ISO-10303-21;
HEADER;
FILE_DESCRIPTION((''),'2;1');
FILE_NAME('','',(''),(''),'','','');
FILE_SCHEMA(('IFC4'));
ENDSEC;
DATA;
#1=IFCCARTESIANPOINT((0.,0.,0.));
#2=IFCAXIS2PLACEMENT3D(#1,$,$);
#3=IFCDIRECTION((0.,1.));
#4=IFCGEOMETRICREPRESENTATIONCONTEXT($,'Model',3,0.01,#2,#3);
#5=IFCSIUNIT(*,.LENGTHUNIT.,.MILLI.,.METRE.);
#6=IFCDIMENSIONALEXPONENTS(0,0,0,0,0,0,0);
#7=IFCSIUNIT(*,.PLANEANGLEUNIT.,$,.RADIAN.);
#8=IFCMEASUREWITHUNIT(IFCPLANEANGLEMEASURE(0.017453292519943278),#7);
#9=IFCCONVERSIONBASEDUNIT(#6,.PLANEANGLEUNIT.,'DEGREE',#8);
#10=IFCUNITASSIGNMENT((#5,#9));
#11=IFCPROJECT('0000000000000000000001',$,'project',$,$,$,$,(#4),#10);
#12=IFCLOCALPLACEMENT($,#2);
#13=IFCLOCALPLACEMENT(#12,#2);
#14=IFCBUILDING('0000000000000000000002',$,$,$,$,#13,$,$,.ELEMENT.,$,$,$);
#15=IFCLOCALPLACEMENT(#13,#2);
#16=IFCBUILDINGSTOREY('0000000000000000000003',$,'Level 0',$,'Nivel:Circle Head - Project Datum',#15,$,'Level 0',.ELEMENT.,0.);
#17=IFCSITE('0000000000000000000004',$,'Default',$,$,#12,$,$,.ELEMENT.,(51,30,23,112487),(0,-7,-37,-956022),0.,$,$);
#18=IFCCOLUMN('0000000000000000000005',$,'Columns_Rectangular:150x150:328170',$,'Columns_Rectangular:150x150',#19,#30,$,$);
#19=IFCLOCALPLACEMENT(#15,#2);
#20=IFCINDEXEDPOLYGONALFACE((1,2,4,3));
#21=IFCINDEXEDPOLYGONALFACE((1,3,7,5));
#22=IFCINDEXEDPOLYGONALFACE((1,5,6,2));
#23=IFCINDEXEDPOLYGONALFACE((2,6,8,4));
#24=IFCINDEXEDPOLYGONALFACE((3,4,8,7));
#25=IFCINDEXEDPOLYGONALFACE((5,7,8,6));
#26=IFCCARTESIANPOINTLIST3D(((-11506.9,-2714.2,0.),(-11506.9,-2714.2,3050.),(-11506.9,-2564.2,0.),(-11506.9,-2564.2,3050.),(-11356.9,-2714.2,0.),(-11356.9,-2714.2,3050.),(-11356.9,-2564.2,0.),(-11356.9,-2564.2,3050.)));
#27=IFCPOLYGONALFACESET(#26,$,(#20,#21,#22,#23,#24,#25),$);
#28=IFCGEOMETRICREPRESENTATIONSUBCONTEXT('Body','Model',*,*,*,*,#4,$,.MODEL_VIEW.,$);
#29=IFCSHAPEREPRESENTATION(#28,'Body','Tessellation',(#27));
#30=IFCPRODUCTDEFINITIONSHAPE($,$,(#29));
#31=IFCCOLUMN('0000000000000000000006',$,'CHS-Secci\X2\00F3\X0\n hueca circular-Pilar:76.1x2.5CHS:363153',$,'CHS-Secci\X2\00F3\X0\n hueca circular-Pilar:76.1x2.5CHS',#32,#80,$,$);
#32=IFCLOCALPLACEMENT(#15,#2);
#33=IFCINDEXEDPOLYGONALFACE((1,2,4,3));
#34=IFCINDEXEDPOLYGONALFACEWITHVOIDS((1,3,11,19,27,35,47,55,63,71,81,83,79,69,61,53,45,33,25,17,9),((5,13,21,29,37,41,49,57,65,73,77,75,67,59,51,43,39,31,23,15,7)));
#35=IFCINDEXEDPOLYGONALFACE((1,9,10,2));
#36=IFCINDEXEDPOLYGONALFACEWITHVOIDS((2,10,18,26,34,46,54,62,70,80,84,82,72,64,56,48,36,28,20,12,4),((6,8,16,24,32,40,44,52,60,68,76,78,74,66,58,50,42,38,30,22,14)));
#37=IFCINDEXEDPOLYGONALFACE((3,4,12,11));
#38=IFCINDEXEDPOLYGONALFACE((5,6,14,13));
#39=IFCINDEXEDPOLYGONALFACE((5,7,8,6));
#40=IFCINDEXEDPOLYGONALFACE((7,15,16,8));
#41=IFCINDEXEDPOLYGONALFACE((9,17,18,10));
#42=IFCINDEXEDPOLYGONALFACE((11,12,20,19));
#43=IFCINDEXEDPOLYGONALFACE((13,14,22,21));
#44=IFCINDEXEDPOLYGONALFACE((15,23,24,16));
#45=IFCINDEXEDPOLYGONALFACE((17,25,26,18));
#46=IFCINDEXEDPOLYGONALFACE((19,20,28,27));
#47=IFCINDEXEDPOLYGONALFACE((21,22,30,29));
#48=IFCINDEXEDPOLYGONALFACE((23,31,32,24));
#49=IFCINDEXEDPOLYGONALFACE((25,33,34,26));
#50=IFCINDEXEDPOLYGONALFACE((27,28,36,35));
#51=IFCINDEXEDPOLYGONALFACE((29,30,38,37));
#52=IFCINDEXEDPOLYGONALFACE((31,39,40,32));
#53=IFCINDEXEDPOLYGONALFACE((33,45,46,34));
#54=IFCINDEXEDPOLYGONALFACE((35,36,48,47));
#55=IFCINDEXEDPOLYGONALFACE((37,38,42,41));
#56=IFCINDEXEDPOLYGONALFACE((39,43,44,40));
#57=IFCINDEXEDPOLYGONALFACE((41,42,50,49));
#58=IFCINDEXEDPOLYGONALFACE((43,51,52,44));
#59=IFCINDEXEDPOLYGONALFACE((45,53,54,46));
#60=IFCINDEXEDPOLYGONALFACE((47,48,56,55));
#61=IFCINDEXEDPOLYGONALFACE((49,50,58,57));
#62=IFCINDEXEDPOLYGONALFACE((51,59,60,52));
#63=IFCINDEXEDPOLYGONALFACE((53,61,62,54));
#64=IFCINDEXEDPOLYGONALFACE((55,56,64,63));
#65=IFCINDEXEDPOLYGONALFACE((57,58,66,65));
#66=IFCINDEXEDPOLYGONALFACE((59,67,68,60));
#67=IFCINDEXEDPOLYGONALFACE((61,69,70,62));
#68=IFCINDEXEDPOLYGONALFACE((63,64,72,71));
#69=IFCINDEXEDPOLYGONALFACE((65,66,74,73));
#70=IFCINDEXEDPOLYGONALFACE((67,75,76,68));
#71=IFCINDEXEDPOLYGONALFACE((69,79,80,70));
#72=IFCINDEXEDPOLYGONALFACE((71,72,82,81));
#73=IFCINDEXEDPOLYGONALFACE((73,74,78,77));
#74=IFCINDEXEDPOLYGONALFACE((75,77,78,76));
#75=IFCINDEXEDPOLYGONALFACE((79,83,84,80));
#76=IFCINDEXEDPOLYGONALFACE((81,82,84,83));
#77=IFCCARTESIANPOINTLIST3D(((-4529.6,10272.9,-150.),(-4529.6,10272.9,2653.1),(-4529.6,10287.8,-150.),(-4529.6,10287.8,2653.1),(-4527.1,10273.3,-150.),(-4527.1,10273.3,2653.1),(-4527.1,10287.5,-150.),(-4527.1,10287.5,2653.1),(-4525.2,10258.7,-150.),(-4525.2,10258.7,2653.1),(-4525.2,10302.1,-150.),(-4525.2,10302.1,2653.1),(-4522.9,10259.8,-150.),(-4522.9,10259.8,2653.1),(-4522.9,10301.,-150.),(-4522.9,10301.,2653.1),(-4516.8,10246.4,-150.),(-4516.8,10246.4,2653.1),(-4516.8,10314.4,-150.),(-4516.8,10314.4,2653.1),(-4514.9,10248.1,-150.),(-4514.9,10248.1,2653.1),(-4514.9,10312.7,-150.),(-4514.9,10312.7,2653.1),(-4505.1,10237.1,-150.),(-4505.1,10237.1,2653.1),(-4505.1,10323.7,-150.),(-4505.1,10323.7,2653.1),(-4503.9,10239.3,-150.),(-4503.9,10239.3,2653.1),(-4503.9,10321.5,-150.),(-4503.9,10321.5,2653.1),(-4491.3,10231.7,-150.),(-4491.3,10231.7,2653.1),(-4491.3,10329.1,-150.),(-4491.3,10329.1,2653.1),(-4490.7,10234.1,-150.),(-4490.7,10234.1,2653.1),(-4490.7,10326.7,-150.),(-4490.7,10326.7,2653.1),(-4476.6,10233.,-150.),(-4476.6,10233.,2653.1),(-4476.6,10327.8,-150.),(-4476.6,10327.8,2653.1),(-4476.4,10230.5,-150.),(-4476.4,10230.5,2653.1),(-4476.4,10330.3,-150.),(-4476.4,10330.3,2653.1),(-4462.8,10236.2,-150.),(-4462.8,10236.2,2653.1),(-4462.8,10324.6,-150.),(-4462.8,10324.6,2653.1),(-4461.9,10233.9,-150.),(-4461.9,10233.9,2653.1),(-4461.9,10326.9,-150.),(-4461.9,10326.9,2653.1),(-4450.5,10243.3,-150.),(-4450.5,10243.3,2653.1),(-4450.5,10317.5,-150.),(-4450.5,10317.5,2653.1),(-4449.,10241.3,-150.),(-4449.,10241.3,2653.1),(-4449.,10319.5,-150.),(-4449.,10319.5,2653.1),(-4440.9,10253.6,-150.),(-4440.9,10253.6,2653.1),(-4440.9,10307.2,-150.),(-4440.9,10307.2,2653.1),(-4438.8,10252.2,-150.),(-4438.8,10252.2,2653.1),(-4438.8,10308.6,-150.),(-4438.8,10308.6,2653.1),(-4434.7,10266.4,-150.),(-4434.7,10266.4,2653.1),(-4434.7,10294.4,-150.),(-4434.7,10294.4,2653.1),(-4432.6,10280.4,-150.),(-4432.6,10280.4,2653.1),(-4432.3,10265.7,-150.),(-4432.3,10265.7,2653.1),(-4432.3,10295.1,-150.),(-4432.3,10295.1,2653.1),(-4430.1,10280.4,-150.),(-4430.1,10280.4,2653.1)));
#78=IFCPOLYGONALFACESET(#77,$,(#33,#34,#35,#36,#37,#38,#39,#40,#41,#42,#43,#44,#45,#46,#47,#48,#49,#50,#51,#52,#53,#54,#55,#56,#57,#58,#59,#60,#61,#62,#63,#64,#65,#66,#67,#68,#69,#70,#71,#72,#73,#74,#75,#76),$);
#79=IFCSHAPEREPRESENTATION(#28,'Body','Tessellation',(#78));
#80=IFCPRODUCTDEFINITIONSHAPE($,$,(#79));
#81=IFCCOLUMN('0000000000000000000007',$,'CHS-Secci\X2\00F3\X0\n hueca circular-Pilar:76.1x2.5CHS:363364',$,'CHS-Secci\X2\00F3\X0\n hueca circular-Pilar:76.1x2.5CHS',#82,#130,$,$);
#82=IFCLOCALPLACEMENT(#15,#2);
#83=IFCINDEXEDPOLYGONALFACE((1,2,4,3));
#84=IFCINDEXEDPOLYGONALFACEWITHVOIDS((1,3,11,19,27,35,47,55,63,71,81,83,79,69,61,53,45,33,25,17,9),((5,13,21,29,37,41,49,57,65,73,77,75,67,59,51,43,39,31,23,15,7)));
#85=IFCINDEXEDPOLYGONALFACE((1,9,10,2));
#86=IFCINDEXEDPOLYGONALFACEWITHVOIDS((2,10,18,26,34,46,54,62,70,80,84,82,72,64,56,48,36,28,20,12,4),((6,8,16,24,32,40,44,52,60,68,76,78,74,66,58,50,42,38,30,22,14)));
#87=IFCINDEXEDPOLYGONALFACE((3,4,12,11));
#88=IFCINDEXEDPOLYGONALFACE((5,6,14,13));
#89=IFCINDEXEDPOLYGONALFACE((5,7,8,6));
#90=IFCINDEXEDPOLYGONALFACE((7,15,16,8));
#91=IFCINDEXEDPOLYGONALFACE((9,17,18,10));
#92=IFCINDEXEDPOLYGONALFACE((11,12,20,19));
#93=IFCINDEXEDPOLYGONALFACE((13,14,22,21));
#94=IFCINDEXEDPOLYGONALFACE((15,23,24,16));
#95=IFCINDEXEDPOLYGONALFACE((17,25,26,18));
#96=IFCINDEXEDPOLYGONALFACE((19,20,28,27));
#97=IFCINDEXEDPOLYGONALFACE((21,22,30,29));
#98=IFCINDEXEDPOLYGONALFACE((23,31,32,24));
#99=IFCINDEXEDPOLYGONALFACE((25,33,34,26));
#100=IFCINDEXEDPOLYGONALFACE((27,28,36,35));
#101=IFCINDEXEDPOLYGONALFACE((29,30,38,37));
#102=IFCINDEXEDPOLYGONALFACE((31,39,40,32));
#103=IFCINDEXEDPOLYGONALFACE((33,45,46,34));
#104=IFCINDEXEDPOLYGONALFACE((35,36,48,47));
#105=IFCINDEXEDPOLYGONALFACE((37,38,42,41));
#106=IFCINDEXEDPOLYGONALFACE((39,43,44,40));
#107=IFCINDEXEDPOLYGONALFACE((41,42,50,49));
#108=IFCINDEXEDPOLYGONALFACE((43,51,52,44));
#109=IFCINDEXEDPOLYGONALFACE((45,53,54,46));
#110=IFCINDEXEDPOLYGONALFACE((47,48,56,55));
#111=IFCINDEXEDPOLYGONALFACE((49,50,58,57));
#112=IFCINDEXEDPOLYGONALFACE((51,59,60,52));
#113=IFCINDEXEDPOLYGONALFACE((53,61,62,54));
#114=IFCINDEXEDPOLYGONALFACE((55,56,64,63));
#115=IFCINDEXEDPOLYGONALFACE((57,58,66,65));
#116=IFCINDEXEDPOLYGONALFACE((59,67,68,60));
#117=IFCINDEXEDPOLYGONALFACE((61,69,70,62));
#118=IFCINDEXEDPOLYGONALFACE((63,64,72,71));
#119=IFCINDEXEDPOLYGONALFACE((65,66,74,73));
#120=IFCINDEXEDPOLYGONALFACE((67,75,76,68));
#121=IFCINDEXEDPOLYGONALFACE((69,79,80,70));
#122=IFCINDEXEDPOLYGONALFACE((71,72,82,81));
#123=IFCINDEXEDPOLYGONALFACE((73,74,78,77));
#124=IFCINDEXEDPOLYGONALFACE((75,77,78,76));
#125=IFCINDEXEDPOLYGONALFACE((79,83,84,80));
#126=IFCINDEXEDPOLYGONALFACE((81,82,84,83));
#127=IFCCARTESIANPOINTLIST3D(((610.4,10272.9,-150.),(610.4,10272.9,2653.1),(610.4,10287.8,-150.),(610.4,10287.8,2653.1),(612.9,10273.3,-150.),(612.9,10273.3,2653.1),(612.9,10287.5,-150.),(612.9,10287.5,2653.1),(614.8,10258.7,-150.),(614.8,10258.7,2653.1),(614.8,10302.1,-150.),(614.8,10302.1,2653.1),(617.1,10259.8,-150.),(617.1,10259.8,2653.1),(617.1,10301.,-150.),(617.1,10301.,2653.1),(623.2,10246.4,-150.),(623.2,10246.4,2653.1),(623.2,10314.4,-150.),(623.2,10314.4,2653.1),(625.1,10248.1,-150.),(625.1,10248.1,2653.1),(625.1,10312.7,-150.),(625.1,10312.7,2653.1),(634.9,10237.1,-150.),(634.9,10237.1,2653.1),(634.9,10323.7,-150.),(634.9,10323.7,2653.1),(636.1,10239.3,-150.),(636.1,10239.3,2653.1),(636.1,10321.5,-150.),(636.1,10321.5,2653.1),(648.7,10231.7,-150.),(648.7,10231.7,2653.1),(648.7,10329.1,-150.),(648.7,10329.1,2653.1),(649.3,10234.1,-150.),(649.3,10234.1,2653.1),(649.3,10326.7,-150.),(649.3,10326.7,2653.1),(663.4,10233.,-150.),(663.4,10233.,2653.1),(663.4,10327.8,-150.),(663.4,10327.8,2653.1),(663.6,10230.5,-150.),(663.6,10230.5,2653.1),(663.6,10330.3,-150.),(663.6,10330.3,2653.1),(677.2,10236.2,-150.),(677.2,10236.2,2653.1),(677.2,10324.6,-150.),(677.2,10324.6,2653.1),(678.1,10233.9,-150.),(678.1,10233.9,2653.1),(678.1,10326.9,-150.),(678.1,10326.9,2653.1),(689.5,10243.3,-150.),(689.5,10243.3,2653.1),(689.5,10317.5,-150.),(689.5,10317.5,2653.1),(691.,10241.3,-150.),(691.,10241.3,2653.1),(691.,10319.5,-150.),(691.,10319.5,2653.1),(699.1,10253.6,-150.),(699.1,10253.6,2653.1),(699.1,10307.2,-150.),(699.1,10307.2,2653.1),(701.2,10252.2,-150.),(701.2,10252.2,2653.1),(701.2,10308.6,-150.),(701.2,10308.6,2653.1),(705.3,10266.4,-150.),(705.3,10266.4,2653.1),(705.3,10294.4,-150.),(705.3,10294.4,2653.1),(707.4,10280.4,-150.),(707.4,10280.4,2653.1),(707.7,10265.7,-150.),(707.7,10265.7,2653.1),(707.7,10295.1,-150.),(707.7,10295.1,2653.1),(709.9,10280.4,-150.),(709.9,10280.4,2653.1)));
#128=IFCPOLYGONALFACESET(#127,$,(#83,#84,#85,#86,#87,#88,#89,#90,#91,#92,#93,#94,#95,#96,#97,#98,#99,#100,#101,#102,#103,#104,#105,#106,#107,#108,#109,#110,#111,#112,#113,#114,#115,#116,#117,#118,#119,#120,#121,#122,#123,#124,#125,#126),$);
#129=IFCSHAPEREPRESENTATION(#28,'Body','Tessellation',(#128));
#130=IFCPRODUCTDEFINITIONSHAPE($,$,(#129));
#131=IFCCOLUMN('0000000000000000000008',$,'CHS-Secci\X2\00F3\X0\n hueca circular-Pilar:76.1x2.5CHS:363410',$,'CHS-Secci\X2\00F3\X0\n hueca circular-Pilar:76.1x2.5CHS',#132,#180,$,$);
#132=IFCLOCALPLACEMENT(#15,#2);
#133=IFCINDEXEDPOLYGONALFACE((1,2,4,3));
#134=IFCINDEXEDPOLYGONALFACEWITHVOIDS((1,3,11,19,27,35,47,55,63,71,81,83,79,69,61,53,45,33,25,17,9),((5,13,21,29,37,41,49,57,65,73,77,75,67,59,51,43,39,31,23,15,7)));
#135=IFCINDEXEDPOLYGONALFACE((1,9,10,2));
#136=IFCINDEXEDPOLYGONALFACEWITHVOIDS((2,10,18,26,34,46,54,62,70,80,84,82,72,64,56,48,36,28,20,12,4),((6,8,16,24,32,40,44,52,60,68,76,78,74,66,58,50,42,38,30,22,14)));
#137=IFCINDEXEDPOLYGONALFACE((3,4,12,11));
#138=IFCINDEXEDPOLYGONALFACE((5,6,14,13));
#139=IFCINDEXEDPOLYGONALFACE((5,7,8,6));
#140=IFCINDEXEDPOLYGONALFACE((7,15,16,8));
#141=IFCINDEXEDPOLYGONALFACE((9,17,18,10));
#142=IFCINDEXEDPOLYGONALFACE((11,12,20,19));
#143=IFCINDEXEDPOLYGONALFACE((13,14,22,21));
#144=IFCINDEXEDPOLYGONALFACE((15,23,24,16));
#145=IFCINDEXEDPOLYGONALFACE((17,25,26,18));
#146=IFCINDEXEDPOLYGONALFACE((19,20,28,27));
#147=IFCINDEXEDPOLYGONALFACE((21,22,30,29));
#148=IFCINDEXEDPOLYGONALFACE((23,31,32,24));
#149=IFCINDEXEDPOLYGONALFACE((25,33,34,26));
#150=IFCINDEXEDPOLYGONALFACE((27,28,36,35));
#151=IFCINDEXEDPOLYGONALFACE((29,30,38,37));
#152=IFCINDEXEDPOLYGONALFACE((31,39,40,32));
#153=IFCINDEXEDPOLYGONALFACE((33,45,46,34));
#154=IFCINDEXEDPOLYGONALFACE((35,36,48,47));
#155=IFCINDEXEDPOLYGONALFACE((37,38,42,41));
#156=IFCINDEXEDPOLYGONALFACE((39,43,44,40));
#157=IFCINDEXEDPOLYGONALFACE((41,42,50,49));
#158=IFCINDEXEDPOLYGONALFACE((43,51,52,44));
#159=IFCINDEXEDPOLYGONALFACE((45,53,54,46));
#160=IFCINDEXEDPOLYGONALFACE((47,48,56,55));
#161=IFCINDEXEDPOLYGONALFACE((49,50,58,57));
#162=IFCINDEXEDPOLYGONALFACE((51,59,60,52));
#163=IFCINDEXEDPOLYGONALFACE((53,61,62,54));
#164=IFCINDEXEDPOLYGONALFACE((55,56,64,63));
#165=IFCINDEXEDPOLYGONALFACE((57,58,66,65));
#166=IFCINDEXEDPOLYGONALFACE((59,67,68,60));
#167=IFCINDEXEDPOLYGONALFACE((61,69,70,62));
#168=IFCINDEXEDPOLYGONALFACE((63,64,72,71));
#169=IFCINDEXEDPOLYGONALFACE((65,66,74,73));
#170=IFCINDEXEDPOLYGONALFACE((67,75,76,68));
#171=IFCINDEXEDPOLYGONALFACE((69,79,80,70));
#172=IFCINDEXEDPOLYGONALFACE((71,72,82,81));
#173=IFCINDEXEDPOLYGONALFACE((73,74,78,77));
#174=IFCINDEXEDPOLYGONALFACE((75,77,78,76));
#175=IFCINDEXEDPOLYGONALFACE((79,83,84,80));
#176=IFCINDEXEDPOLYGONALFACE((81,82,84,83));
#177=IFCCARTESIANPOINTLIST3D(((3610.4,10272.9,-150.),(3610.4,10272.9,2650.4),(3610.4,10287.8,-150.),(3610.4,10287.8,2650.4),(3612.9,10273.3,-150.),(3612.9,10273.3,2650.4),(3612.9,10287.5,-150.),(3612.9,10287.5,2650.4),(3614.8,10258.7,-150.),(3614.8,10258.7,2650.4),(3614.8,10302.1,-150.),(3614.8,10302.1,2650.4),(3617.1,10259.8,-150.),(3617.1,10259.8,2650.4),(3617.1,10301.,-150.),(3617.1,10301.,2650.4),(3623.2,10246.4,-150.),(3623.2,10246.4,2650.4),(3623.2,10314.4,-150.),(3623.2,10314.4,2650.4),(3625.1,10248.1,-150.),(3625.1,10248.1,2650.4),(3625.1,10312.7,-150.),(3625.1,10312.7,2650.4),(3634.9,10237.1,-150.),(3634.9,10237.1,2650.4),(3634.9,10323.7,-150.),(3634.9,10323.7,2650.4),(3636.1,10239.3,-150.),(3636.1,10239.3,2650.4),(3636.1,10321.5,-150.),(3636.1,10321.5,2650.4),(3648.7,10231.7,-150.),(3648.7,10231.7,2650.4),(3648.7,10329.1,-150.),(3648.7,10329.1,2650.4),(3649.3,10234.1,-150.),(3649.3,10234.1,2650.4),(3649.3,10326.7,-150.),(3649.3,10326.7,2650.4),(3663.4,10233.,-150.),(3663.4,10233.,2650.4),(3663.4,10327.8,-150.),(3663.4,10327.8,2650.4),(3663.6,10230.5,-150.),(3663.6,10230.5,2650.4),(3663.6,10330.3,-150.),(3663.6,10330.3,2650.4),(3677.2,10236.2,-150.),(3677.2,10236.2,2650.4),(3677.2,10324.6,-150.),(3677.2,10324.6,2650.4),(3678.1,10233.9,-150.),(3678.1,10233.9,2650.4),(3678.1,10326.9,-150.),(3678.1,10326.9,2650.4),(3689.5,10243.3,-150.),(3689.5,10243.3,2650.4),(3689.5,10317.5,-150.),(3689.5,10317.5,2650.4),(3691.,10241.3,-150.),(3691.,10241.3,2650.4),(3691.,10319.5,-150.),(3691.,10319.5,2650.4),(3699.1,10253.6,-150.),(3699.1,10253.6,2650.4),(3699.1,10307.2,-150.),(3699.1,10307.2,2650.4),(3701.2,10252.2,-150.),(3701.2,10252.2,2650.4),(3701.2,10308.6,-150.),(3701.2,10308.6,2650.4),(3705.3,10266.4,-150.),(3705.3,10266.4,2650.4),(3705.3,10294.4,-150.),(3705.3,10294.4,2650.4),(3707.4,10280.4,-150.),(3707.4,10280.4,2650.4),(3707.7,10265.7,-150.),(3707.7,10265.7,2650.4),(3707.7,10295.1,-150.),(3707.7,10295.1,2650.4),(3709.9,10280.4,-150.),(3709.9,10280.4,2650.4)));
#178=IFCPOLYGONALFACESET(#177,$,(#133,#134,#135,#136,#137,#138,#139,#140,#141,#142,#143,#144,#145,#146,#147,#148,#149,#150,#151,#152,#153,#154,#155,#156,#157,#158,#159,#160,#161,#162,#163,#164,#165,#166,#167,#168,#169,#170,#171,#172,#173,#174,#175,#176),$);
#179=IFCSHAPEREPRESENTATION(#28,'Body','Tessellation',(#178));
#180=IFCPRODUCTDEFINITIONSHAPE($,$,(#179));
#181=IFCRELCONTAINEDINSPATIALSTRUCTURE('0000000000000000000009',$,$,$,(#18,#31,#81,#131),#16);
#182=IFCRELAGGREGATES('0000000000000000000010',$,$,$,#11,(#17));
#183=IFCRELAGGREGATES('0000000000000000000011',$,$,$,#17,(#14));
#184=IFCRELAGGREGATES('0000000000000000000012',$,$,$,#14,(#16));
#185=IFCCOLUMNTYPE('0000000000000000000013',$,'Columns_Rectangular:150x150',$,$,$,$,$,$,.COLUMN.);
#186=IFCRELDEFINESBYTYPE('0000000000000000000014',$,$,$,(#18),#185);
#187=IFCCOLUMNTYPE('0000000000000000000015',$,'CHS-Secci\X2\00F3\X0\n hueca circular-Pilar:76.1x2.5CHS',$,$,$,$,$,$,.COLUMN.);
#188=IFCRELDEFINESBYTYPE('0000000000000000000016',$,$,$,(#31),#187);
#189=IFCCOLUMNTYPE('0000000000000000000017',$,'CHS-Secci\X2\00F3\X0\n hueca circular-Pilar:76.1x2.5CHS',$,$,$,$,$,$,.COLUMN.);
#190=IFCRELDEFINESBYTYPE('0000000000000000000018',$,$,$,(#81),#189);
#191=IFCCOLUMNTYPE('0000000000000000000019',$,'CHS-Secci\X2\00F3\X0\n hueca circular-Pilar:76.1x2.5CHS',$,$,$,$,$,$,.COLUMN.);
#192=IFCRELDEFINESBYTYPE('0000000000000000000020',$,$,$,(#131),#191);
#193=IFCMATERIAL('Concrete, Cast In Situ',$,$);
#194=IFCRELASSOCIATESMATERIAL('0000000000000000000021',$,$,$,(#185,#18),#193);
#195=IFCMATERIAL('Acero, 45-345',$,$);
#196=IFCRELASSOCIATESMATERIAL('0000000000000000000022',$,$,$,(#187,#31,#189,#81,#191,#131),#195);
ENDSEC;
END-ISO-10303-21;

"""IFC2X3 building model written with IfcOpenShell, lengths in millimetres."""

from ifc_helpers import new_model, entity, si_unit, converted_unit, direction, frame, frame_2d, origin, origin_2d_with_axis, place, context, subcontext, project, spatial, rectangle, hollow_circle, extrude, source, transform, mapped, material, type_object, type_shapes, element, save


model = new_model("IFC2X3")

# Units and contexts
model_context = context("Model", 3, precision=0.01, world=origin(), true_north=direction((0.0, 1.0)))
body_context = subcontext(model_context, "Body", "Model", "MODEL_VIEW")
ifc_project = project(units=[si_unit("LENGTHUNIT", "METRE", prefix="MILLI"), converted_unit("PLANEANGLEUNIT", "DEGREE", entity("IfcPlaneAngleMeasure", 0.017453292519943278), si_unit("PLANEANGLEUNIT", "RADIAN"), dimensions=[0, 0, 0, 0, 0, 0, 0])], contexts=[model_context])

# Site, building, storey
site_placement = place(None, origin())
site = spatial("IfcSite", under=ifc_project, at=site_placement, Name="Default", CompositionType="ELEMENT", RefLatitude=(51, 30, 23, 112487), RefLongitude=(0, -7, -37, -956022), RefElevation=0.0)
building_placement = place(site_placement, origin())
building = spatial("IfcBuilding", under=site, at=building_placement, CompositionType="ELEMENT")
storey_placement = place(building_placement, origin())
storey = spatial("IfcBuildingStorey", under=building, at=storey_placement, Name="Level 0", ObjectType="Nivel:Circle Head - Project Datum", LongName="Level 0", CompositionType="ELEMENT", Elevation=0.0)

# Columns
ifc_material_1 = material(Name="Concrete, Cast In Situ")
column_type_1 = type_object("IfcColumnType", Name="Columns_Rectangular:150x150", PredefinedType="COLUMN", material=ifc_material_1)
shared_shape_1 = source(origin(), body_context, "Body", "SweptSolid", [
    extrude(rectangle(XDim=150.0, YDim=150.0, at=frame_2d((0.0, 0.0), x_axis=(1.0, 0.0))), frame((-11431.9, -2639.2, 0.0), z_axis=(0.0, 0.0, 1.0), x_axis=(-1.0, 0.0, 0.0)), (0.0, 0.0, 1.0), 3050.0),
])
type_shapes(column_type_1, [shared_shape_1])
column_1_placement = place(storey_placement, origin())
element("IfcColumn", 1, at=column_1_placement, inside=storey, type_object=column_type_1, material=ifc_material_1, Name="Columns_Rectangular:150x150:328170", ObjectType="Columns_Rectangular:150x150", context=body_context, shape_type="MappedRepresentation", body=[
    mapped(shared_shape_1, transform((0.0, 0.0, 0.0), scale=1.0)),
])
ifc_material_2 = material(Name="Acero, 45-345")
column_type_2 = type_object("IfcColumnType", Name="CHS-Sección hueca circular-Pilar:76.1x2.5CHS", PredefinedType="COLUMN", material=ifc_material_2)
shared_shape_2 = source(origin(), body_context, "Body", "SweptSolid", [
    extrude(hollow_circle(Radius=50.0, WallThickness=2.5, at=origin_2d_with_axis()), frame((-4480.1, 10280.4, -150.0)), (0.0, 0.0, 1.0), 2803.1),
])
type_shapes(column_type_2, [shared_shape_2])
column_2_placement = place(storey_placement, origin())
element("IfcColumn", 2, at=column_2_placement, inside=storey, type_object=column_type_2, material=ifc_material_2, Name="CHS-Sección hueca circular-Pilar:76.1x2.5CHS:363153", ObjectType="CHS-Sección hueca circular-Pilar:76.1x2.5CHS", context=body_context, shape_type="MappedRepresentation", body=[
    mapped(shared_shape_2, transform((0.0, 0.0, 0.0), scale=1.0)),
])
column_type_3 = type_object("IfcColumnType", Name="CHS-Sección hueca circular-Pilar:76.1x2.5CHS", PredefinedType="COLUMN", material=ifc_material_2)
shared_shape_3 = source(origin(), body_context, "Body", "SweptSolid", [
    extrude(hollow_circle(Radius=50.0, WallThickness=2.5, at=origin_2d_with_axis()), frame((659.9, 10280.4, -150.0)), (0.0, 0.0, 1.0), 2803.1),
])
type_shapes(column_type_3, [shared_shape_3])
column_3_placement = place(storey_placement, origin())
element("IfcColumn", 3, at=column_3_placement, inside=storey, type_object=column_type_3, material=ifc_material_2, Name="CHS-Sección hueca circular-Pilar:76.1x2.5CHS:363364", ObjectType="CHS-Sección hueca circular-Pilar:76.1x2.5CHS", context=body_context, shape_type="MappedRepresentation", body=[
    mapped(shared_shape_3, transform((0.0, 0.0, 0.0), scale=1.0)),
])
column_type_4 = type_object("IfcColumnType", Name="CHS-Sección hueca circular-Pilar:76.1x2.5CHS", PredefinedType="COLUMN", material=ifc_material_2)
shared_shape_4 = source(origin(), body_context, "Body", "SweptSolid", [
    extrude(hollow_circle(Radius=50.0, WallThickness=2.5, at=origin_2d_with_axis()), frame((3659.9, 10280.4, -150.0)), (0.0, 0.0, 1.0), 2800.4),
])
type_shapes(column_type_4, [shared_shape_4])
column_4_placement = place(storey_placement, origin())
element("IfcColumn", 4, at=column_4_placement, inside=storey, type_object=column_type_4, material=ifc_material_2, Name="CHS-Sección hueca circular-Pilar:76.1x2.5CHS:363410", ObjectType="CHS-Sección hueca circular-Pilar:76.1x2.5CHS", context=body_context, shape_type="MappedRepresentation", body=[
    mapped(shared_shape_4, transform((0.0, 0.0, 0.0), scale=1.0)),
])

save(model, "model.ifc")
